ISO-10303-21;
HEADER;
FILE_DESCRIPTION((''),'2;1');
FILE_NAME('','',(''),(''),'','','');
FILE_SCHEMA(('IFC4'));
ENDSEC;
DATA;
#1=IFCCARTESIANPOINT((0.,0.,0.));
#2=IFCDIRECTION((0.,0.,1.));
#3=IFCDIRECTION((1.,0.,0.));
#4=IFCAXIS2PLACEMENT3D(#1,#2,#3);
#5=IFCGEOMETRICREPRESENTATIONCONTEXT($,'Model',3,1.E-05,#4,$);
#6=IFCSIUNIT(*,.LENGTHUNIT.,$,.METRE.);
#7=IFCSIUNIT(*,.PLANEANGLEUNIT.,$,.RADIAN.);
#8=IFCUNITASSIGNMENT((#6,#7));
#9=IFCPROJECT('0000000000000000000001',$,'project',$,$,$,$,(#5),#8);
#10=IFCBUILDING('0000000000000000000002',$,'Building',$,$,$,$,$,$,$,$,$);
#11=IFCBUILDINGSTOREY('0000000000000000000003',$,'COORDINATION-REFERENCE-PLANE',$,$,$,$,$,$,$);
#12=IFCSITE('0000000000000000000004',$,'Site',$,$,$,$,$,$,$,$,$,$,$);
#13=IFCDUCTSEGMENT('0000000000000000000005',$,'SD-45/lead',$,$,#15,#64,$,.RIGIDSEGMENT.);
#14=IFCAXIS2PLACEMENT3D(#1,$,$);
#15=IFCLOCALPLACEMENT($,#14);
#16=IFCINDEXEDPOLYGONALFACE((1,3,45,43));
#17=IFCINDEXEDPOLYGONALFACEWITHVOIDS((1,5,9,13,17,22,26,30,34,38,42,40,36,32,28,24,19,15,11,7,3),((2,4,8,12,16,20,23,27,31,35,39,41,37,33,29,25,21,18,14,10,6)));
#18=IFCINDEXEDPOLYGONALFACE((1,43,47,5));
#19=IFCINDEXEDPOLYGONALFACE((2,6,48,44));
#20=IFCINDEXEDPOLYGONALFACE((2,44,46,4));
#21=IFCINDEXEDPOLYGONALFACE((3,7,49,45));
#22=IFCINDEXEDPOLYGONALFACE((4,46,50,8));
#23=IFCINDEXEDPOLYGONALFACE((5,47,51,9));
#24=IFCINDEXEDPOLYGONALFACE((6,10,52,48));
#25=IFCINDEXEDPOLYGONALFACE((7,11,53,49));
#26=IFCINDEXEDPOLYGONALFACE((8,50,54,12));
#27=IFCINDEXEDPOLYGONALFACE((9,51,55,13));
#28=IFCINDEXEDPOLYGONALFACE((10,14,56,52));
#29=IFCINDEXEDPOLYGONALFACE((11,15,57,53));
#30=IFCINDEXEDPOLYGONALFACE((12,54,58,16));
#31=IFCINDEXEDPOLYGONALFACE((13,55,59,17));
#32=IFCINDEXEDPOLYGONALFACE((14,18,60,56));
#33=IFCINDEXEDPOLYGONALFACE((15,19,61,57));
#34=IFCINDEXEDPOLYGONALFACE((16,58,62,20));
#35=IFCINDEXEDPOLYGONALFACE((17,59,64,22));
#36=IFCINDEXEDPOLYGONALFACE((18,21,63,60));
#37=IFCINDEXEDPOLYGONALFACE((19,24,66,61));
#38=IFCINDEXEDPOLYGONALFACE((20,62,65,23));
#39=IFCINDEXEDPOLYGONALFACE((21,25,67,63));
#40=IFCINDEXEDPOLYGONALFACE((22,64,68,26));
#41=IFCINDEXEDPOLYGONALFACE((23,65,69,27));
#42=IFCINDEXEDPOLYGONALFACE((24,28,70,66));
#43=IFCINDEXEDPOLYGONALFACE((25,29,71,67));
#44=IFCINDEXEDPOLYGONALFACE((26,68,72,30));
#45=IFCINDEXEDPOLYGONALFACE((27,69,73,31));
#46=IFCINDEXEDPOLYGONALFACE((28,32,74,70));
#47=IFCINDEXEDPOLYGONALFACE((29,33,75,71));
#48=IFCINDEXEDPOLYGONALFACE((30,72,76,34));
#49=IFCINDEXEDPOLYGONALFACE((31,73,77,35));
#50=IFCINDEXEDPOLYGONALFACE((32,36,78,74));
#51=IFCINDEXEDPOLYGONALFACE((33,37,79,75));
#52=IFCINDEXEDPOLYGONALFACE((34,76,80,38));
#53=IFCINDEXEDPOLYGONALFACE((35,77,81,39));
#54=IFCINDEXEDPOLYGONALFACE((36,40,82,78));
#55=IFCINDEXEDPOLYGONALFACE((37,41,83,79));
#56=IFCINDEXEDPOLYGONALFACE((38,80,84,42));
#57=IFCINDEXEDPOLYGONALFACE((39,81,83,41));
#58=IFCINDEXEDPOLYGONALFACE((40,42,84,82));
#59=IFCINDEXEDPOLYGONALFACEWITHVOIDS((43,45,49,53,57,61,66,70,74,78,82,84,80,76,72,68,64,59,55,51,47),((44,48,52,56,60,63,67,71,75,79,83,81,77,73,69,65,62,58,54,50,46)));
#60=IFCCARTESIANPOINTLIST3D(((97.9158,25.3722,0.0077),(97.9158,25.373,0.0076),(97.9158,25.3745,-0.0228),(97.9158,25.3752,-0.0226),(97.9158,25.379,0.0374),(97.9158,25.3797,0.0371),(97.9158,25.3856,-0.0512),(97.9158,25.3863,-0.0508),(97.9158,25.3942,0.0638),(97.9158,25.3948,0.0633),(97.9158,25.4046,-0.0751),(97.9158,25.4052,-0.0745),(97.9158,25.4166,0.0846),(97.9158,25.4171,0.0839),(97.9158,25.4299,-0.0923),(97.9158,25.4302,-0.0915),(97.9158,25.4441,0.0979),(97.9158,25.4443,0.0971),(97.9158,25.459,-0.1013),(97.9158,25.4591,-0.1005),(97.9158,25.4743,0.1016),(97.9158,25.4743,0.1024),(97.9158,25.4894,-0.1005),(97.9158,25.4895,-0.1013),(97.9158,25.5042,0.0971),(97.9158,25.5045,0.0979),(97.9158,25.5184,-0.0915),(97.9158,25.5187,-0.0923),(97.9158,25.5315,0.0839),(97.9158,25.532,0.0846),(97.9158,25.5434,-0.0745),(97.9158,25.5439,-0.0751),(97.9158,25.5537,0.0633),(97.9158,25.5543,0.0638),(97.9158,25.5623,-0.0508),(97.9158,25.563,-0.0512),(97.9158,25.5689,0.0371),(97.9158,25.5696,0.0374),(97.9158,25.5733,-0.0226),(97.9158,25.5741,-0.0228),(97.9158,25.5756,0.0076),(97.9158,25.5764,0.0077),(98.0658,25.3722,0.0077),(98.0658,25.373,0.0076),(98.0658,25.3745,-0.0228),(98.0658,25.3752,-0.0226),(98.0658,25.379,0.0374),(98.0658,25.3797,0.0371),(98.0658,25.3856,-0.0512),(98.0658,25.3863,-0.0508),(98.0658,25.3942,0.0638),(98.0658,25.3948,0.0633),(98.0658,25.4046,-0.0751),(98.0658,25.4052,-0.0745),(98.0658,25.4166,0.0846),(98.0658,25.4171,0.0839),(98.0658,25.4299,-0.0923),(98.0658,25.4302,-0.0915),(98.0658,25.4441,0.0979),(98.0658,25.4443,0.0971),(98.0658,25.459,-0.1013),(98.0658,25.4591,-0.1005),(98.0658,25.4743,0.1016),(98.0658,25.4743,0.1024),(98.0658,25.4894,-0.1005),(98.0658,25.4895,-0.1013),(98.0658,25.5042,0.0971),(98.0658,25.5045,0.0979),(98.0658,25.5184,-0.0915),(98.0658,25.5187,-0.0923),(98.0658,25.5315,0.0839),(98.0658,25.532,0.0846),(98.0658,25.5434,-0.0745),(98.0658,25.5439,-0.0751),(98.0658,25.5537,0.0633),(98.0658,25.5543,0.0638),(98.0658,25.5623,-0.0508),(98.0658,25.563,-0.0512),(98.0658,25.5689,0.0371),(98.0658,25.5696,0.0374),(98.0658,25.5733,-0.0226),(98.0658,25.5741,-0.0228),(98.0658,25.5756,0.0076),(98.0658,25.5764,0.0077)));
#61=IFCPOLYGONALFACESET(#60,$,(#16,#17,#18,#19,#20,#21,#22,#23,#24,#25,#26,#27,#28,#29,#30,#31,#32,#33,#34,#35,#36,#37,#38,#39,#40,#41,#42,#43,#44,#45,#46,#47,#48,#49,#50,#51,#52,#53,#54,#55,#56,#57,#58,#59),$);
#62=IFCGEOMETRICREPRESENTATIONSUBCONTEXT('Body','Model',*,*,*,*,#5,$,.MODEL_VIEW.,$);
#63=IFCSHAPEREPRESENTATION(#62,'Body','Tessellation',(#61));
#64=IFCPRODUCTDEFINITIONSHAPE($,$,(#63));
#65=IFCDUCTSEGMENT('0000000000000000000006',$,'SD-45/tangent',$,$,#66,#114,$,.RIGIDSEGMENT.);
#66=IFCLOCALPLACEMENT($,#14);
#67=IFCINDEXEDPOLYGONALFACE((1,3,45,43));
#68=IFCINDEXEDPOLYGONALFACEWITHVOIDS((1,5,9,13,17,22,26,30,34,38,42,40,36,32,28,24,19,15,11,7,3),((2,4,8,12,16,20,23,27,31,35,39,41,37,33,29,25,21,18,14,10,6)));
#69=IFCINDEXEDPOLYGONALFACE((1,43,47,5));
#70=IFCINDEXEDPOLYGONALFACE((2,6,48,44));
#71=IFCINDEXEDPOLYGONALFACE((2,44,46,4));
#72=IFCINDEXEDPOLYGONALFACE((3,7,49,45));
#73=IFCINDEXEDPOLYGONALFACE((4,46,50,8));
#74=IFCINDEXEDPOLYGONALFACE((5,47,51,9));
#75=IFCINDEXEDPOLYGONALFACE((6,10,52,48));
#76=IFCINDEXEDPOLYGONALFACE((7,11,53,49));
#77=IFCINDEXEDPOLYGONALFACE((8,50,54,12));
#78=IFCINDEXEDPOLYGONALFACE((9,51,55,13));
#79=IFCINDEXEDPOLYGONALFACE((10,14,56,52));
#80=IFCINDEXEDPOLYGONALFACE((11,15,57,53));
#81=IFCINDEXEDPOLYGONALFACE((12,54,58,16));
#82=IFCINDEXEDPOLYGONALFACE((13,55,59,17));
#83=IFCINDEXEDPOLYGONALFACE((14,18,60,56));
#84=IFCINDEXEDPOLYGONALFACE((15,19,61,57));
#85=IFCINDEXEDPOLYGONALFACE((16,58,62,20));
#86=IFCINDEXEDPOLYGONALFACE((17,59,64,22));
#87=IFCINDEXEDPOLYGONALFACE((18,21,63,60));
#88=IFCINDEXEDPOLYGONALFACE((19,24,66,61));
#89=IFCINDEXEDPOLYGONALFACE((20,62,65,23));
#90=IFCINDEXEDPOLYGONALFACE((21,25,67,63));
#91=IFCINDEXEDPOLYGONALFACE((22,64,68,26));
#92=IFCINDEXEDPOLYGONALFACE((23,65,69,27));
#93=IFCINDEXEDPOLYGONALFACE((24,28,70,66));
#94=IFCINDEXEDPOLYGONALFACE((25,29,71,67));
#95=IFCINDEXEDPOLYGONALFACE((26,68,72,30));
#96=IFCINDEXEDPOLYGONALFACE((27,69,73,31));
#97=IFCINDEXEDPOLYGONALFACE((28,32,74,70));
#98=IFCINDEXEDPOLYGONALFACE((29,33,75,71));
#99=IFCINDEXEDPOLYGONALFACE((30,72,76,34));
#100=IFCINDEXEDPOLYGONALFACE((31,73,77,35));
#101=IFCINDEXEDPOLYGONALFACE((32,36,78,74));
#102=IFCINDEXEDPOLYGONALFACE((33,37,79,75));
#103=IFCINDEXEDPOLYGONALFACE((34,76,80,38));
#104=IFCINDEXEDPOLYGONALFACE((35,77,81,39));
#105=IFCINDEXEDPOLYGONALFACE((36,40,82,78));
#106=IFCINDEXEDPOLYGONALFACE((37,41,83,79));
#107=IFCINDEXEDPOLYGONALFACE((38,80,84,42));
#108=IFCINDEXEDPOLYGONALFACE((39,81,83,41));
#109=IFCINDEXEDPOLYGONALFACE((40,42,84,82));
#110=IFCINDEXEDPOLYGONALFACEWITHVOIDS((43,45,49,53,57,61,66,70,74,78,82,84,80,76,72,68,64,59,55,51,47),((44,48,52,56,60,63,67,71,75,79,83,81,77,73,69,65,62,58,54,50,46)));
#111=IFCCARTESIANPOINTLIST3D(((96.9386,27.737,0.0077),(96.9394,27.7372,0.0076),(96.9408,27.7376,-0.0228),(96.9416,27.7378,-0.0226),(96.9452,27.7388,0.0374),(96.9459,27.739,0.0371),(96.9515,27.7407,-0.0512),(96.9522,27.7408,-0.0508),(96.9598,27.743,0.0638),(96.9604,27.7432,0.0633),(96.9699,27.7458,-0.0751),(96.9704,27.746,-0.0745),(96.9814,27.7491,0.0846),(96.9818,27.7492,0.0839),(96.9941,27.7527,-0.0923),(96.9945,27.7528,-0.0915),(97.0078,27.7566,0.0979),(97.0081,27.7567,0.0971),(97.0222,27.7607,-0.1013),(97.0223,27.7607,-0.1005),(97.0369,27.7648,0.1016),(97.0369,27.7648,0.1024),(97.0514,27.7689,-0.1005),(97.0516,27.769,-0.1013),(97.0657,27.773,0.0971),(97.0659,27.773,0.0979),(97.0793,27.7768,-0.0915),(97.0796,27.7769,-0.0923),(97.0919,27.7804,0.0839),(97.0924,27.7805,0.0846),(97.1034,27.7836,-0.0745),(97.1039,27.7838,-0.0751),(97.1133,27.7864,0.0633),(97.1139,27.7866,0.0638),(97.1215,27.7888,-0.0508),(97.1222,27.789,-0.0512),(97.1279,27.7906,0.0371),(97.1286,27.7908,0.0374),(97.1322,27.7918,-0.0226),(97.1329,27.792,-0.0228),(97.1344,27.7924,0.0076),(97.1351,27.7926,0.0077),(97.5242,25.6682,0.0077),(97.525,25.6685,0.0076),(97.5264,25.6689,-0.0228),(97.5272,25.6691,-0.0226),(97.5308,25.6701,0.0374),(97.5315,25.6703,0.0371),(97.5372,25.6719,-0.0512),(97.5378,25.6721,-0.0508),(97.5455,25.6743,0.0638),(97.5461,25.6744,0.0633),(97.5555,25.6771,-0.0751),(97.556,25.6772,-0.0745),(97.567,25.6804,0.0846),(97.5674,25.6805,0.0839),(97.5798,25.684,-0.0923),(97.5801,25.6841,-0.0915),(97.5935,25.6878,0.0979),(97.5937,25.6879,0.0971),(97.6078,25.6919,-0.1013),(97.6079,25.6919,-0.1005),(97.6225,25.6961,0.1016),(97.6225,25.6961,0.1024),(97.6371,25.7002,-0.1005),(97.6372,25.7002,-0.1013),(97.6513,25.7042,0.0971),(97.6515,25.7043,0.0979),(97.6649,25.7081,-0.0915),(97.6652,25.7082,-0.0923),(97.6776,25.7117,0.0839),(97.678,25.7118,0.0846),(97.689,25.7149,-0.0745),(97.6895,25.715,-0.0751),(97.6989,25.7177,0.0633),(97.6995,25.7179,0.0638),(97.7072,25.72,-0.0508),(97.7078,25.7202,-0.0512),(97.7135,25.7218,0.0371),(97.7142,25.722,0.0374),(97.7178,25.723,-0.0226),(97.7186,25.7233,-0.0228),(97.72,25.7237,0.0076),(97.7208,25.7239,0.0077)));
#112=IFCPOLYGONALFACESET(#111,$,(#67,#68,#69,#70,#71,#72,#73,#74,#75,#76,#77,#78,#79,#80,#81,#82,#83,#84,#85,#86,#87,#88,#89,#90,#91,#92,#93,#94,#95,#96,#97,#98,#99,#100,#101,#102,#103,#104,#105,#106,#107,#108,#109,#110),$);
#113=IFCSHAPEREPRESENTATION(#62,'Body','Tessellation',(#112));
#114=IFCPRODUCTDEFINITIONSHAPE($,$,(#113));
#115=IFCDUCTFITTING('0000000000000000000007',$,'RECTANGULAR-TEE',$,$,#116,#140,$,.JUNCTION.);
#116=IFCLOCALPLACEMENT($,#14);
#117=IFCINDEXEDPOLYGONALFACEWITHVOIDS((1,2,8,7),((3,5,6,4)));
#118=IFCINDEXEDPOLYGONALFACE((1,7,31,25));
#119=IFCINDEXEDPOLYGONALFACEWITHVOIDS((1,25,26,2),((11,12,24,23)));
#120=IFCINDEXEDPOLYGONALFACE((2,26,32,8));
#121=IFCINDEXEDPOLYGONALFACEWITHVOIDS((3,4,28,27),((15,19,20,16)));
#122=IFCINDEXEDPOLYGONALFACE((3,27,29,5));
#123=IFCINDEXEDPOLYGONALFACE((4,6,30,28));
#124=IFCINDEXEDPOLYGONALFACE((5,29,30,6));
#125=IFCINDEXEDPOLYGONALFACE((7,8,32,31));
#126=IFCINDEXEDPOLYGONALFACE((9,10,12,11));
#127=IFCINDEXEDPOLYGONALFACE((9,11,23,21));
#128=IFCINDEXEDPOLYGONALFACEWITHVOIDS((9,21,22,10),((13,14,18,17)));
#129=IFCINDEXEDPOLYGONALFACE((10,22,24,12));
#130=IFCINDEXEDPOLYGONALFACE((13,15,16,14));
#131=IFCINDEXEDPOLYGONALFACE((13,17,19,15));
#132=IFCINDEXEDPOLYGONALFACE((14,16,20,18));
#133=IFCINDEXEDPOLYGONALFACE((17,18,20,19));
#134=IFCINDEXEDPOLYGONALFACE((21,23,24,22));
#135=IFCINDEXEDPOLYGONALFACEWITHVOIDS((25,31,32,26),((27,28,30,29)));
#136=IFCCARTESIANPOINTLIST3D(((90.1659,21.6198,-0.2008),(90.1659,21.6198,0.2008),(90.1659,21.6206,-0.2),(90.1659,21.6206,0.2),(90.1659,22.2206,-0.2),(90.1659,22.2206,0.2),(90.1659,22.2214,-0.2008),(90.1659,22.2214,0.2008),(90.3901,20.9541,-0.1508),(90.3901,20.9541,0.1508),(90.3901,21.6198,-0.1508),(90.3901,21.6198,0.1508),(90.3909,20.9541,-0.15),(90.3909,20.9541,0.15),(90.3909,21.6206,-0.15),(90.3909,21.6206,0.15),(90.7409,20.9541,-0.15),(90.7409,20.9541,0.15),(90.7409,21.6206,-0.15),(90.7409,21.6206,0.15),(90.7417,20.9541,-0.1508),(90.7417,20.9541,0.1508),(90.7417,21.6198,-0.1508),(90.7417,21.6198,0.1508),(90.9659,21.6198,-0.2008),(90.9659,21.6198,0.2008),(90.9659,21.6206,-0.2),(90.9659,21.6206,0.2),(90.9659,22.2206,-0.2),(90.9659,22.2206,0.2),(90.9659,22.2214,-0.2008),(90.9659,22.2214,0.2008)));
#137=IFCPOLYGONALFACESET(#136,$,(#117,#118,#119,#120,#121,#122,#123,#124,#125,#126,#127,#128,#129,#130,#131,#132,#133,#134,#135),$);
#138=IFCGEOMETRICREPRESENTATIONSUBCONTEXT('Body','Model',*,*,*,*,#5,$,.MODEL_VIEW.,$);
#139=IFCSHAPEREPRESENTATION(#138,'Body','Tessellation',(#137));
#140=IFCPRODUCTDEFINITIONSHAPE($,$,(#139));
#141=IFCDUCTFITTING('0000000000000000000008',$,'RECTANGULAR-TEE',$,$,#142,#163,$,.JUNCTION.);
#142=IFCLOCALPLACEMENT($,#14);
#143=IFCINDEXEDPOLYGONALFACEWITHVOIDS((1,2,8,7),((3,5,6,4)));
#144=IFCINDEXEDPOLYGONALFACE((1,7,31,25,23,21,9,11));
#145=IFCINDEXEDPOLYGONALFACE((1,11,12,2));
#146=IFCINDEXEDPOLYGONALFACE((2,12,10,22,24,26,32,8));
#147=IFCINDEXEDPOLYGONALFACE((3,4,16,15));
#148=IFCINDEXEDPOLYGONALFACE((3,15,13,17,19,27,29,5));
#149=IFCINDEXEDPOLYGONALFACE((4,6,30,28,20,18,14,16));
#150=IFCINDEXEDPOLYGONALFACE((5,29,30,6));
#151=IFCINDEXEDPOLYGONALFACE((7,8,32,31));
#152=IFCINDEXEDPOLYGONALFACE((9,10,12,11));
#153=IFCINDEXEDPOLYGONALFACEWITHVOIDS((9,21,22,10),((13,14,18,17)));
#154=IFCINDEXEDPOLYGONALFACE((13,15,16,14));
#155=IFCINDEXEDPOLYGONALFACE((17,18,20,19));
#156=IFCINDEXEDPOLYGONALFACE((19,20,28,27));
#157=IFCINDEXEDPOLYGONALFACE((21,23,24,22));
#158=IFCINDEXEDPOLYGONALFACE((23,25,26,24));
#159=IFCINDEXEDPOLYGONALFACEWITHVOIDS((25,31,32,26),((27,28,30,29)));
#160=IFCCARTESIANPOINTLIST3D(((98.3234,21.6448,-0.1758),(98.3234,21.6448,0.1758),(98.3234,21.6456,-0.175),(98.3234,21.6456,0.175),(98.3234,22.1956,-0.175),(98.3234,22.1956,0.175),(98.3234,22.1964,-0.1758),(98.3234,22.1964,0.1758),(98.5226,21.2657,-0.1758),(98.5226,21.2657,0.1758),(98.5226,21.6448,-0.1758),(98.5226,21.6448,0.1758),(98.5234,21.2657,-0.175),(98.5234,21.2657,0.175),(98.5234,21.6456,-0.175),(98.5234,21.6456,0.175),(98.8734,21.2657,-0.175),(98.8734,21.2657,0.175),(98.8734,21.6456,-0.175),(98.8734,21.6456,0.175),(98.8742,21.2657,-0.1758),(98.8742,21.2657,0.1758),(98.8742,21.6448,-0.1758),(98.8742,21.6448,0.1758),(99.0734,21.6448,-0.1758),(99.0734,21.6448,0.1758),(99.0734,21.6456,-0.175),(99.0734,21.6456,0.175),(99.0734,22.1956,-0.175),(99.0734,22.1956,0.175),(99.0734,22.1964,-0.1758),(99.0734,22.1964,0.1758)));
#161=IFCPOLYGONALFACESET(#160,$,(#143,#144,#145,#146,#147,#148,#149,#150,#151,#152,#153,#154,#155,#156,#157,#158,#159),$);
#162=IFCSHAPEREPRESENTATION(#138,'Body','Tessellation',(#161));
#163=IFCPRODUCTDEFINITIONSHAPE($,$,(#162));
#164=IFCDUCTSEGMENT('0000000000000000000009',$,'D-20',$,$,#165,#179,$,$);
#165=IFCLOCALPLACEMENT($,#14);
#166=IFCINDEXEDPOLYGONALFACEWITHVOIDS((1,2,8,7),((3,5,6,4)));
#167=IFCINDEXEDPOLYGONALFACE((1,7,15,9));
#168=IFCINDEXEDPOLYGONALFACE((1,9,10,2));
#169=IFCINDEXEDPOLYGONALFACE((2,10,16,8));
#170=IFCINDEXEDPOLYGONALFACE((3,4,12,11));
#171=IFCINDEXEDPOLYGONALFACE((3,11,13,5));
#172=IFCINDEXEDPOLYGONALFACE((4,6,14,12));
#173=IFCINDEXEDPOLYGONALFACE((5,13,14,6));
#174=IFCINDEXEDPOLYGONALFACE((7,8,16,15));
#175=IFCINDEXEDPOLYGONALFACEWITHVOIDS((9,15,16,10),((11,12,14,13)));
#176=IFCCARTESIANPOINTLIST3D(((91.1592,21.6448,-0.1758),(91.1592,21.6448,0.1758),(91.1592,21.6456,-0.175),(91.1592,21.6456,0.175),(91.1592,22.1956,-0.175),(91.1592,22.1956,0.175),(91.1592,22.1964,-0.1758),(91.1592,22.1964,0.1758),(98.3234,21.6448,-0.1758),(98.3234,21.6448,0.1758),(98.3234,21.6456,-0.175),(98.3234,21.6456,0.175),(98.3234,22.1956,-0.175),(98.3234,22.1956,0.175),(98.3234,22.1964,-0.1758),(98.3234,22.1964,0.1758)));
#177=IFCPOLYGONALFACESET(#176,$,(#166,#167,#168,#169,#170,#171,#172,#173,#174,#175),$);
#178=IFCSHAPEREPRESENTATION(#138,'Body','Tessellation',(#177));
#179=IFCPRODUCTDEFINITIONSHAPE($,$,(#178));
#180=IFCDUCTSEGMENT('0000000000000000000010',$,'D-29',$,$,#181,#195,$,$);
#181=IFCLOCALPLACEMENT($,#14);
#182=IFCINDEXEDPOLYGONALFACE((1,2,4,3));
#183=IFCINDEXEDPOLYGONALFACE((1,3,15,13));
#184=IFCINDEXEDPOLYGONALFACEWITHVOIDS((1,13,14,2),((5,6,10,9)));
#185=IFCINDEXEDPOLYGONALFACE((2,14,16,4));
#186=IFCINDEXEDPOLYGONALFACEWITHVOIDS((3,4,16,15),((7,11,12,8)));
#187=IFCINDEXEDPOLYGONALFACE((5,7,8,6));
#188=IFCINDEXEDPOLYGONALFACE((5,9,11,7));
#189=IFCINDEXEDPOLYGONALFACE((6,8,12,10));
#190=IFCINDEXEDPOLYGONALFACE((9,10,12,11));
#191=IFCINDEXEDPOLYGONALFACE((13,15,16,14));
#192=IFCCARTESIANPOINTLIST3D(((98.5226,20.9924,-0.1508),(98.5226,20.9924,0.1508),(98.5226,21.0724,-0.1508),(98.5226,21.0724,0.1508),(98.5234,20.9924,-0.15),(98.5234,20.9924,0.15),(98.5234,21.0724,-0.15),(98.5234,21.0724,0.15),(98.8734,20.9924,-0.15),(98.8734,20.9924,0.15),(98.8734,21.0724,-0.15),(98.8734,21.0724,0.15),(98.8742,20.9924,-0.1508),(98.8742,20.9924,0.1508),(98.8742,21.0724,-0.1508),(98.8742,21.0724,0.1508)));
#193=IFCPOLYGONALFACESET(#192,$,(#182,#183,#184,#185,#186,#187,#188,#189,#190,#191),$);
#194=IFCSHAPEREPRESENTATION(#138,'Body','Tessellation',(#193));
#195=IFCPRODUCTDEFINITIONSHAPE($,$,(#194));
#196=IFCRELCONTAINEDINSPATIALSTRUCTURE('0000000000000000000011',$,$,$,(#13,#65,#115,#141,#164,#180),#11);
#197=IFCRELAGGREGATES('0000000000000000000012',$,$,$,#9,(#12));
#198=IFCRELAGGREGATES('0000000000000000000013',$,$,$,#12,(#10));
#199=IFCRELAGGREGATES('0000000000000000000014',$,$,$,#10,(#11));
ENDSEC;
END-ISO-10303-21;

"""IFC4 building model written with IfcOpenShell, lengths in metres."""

from ifc_helpers import new_model, si_unit, frame, origin, origin_with_axes, place, context, subcontext, project, spatial, rectangle, hollow_rectangle, hollow_circle, extrude, boolean, element, save


model = new_model("IFC4")

# Units and contexts
model_context_1 = context("Model", 3, precision=1e-05, world=origin_with_axes())
body_context_1 = subcontext(model_context_1, "Body", "Model", "MODEL_VIEW")
body_context_2 = subcontext(model_context_1, "Body", "Model", "MODEL_VIEW")
ifc_project = project(units=[si_unit("LENGTHUNIT", "METRE"), si_unit("PLANEANGLEUNIT", "RADIAN")], contexts=[model_context_1])

# Site, building, storey
site = spatial("IfcSite", under=ifc_project, Name="Site")
building = spatial("IfcBuilding", under=site, Name="Building")
storey = spatial("IfcBuildingStorey", under=building, Name="COORDINATION-REFERENCE-PLANE")

# Duct segment
duct_segment_1_placement = place(None, frame((98.0658, 25.4743, 0.0), z_axis=(-1.0, 0.0, 0.0), x_axis=(0.0, 0.0, 1.0)))
element("IfcDuctSegment", 1, at=duct_segment_1_placement, inside=storey, Name="SD-45/lead", PredefinedType="RIGIDSEGMENT", context=body_context_1, shape_type="SweptSolid", body=[
    extrude(hollow_circle(Radius=0.1024, WallThickness=0.0008), origin_with_axes(), (0.0, 0.0, 1.0), 0.15),
])

# Duct segment
duct_segment_2_placement = place(None, frame((97.6225, 25.6961, 0.0), z_axis=(-0.272381, 0.96219, 0.0), x_axis=(0.0, 0.0, 1.0)))
element("IfcDuctSegment", 2, at=duct_segment_2_placement, inside=storey, Name="SD-45/tangent", PredefinedType="RIGIDSEGMENT", context=body_context_1, shape_type="SweptSolid", body=[
    extrude(hollow_circle(Radius=0.1024, WallThickness=0.0008), origin_with_axes(), (0.0, 0.0, 1.0), 2.15),
])

# Duct fittings
duct_fitting_1_placement = place(None, frame((90.5659, 21.9206, 0.0), z_axis=(1.0, 0.0, 0.0), x_axis=(0.0, -1.0, 0.0)))
solid_1 = boolean("UNION", extrude(rectangle(XDim=0.6, YDim=0.4), frame((0.0, 0.0, -0.4), z_axis=(0.0, 0.0, 1.0), x_axis=(1.0, 0.0, 0.0)), (0.0, 0.0, 1.0), 0.8), extrude(rectangle(XDim=0.35, YDim=0.3), frame((0.0, 0.0, 0.0), z_axis=(1.0, 0.0, 0.0), x_axis=(0.0, 0.0, -1.0)), (0.0, 0.0, 1.0), 0.9665))
element("IfcDuctFitting", 3, at=duct_fitting_1_placement, inside=storey, Name="RECTANGULAR-TEE", PredefinedType="JUNCTION", context=body_context_2, shape_type="CSG", body=[
    boolean("DIFFERENCE", boolean("UNION", extrude(rectangle(XDim=0.6016, YDim=0.4016), frame((0.0, 0.0, -0.4), z_axis=(0.0, 0.0, 1.0), x_axis=(1.0, 0.0, 0.0)), (0.0, 0.0, 1.0), 0.8), extrude(rectangle(XDim=0.3516, YDim=0.3016), frame((0.0, 0.0, 0.0), z_axis=(1.0, 0.0, 0.0), x_axis=(0.0, 0.0, -1.0)), (0.0, 0.0, 1.0), 0.9665)), solid_1),
])
duct_fitting_2_placement = place(None, frame((98.6984, 21.9206, 0.0), z_axis=(1.0, 0.0, 0.0), x_axis=(0.0, -1.0, 0.0)))
solid_2 = boolean("UNION", extrude(rectangle(XDim=0.55, YDim=0.35), frame((0.0, 0.0, -0.375), z_axis=(0.0, 0.0, 1.0), x_axis=(1.0, 0.0, 0.0)), (0.0, 0.0, 1.0), 0.75), extrude(rectangle(XDim=0.35, YDim=0.35), frame((0.0, 0.0, 0.0), z_axis=(1.0, 0.0, 0.0), x_axis=(0.0, 0.0, -1.0)), (0.0, 0.0, 1.0), 0.6549))
element("IfcDuctFitting", 4, at=duct_fitting_2_placement, inside=storey, Name="RECTANGULAR-TEE", PredefinedType="JUNCTION", context=body_context_2, shape_type="CSG", body=[
    boolean("DIFFERENCE", boolean("UNION", extrude(rectangle(XDim=0.5516, YDim=0.3516), frame((0.0, 0.0, -0.375), z_axis=(0.0, 0.0, 1.0), x_axis=(1.0, 0.0, 0.0)), (0.0, 0.0, 1.0), 0.75), extrude(rectangle(XDim=0.3516, YDim=0.3516), frame((0.0, 0.0, 0.0), z_axis=(1.0, 0.0, 0.0), x_axis=(0.0, 0.0, -1.0)), (0.0, 0.0, 1.0), 0.6549)), solid_2),
])

# Duct segments
duct_segment_3_placement = place(None, frame((91.1592, 21.9206, 0.0), z_axis=(1.0, 0.0, 0.0), x_axis=(0.0, 1.0, 0.0)))
element("IfcDuctSegment", 5, at=duct_segment_3_placement, inside=storey, Name="D-20", context=body_context_2, shape_type="SweptSolid", body=[
    extrude(hollow_rectangle(XDim=0.5516, YDim=0.3516, WallThickness=0.0008), origin(), (0.0, 0.0, 1.0), 7.1642),
])
duct_segment_4_placement = place(None, frame((98.6984, 20.9924, 0.0), z_axis=(0.0, 1.0, 0.0), x_axis=(1.0, 0.0, 0.0)))
element("IfcDuctSegment", 6, at=duct_segment_4_placement, inside=storey, Name="D-29", context=body_context_2, shape_type="SweptSolid", body=[
    extrude(hollow_rectangle(XDim=0.3516, YDim=0.3016, WallThickness=0.0008), origin(), (0.0, 0.0, 1.0), 0.08),
])

save(model, "model.ifc")
